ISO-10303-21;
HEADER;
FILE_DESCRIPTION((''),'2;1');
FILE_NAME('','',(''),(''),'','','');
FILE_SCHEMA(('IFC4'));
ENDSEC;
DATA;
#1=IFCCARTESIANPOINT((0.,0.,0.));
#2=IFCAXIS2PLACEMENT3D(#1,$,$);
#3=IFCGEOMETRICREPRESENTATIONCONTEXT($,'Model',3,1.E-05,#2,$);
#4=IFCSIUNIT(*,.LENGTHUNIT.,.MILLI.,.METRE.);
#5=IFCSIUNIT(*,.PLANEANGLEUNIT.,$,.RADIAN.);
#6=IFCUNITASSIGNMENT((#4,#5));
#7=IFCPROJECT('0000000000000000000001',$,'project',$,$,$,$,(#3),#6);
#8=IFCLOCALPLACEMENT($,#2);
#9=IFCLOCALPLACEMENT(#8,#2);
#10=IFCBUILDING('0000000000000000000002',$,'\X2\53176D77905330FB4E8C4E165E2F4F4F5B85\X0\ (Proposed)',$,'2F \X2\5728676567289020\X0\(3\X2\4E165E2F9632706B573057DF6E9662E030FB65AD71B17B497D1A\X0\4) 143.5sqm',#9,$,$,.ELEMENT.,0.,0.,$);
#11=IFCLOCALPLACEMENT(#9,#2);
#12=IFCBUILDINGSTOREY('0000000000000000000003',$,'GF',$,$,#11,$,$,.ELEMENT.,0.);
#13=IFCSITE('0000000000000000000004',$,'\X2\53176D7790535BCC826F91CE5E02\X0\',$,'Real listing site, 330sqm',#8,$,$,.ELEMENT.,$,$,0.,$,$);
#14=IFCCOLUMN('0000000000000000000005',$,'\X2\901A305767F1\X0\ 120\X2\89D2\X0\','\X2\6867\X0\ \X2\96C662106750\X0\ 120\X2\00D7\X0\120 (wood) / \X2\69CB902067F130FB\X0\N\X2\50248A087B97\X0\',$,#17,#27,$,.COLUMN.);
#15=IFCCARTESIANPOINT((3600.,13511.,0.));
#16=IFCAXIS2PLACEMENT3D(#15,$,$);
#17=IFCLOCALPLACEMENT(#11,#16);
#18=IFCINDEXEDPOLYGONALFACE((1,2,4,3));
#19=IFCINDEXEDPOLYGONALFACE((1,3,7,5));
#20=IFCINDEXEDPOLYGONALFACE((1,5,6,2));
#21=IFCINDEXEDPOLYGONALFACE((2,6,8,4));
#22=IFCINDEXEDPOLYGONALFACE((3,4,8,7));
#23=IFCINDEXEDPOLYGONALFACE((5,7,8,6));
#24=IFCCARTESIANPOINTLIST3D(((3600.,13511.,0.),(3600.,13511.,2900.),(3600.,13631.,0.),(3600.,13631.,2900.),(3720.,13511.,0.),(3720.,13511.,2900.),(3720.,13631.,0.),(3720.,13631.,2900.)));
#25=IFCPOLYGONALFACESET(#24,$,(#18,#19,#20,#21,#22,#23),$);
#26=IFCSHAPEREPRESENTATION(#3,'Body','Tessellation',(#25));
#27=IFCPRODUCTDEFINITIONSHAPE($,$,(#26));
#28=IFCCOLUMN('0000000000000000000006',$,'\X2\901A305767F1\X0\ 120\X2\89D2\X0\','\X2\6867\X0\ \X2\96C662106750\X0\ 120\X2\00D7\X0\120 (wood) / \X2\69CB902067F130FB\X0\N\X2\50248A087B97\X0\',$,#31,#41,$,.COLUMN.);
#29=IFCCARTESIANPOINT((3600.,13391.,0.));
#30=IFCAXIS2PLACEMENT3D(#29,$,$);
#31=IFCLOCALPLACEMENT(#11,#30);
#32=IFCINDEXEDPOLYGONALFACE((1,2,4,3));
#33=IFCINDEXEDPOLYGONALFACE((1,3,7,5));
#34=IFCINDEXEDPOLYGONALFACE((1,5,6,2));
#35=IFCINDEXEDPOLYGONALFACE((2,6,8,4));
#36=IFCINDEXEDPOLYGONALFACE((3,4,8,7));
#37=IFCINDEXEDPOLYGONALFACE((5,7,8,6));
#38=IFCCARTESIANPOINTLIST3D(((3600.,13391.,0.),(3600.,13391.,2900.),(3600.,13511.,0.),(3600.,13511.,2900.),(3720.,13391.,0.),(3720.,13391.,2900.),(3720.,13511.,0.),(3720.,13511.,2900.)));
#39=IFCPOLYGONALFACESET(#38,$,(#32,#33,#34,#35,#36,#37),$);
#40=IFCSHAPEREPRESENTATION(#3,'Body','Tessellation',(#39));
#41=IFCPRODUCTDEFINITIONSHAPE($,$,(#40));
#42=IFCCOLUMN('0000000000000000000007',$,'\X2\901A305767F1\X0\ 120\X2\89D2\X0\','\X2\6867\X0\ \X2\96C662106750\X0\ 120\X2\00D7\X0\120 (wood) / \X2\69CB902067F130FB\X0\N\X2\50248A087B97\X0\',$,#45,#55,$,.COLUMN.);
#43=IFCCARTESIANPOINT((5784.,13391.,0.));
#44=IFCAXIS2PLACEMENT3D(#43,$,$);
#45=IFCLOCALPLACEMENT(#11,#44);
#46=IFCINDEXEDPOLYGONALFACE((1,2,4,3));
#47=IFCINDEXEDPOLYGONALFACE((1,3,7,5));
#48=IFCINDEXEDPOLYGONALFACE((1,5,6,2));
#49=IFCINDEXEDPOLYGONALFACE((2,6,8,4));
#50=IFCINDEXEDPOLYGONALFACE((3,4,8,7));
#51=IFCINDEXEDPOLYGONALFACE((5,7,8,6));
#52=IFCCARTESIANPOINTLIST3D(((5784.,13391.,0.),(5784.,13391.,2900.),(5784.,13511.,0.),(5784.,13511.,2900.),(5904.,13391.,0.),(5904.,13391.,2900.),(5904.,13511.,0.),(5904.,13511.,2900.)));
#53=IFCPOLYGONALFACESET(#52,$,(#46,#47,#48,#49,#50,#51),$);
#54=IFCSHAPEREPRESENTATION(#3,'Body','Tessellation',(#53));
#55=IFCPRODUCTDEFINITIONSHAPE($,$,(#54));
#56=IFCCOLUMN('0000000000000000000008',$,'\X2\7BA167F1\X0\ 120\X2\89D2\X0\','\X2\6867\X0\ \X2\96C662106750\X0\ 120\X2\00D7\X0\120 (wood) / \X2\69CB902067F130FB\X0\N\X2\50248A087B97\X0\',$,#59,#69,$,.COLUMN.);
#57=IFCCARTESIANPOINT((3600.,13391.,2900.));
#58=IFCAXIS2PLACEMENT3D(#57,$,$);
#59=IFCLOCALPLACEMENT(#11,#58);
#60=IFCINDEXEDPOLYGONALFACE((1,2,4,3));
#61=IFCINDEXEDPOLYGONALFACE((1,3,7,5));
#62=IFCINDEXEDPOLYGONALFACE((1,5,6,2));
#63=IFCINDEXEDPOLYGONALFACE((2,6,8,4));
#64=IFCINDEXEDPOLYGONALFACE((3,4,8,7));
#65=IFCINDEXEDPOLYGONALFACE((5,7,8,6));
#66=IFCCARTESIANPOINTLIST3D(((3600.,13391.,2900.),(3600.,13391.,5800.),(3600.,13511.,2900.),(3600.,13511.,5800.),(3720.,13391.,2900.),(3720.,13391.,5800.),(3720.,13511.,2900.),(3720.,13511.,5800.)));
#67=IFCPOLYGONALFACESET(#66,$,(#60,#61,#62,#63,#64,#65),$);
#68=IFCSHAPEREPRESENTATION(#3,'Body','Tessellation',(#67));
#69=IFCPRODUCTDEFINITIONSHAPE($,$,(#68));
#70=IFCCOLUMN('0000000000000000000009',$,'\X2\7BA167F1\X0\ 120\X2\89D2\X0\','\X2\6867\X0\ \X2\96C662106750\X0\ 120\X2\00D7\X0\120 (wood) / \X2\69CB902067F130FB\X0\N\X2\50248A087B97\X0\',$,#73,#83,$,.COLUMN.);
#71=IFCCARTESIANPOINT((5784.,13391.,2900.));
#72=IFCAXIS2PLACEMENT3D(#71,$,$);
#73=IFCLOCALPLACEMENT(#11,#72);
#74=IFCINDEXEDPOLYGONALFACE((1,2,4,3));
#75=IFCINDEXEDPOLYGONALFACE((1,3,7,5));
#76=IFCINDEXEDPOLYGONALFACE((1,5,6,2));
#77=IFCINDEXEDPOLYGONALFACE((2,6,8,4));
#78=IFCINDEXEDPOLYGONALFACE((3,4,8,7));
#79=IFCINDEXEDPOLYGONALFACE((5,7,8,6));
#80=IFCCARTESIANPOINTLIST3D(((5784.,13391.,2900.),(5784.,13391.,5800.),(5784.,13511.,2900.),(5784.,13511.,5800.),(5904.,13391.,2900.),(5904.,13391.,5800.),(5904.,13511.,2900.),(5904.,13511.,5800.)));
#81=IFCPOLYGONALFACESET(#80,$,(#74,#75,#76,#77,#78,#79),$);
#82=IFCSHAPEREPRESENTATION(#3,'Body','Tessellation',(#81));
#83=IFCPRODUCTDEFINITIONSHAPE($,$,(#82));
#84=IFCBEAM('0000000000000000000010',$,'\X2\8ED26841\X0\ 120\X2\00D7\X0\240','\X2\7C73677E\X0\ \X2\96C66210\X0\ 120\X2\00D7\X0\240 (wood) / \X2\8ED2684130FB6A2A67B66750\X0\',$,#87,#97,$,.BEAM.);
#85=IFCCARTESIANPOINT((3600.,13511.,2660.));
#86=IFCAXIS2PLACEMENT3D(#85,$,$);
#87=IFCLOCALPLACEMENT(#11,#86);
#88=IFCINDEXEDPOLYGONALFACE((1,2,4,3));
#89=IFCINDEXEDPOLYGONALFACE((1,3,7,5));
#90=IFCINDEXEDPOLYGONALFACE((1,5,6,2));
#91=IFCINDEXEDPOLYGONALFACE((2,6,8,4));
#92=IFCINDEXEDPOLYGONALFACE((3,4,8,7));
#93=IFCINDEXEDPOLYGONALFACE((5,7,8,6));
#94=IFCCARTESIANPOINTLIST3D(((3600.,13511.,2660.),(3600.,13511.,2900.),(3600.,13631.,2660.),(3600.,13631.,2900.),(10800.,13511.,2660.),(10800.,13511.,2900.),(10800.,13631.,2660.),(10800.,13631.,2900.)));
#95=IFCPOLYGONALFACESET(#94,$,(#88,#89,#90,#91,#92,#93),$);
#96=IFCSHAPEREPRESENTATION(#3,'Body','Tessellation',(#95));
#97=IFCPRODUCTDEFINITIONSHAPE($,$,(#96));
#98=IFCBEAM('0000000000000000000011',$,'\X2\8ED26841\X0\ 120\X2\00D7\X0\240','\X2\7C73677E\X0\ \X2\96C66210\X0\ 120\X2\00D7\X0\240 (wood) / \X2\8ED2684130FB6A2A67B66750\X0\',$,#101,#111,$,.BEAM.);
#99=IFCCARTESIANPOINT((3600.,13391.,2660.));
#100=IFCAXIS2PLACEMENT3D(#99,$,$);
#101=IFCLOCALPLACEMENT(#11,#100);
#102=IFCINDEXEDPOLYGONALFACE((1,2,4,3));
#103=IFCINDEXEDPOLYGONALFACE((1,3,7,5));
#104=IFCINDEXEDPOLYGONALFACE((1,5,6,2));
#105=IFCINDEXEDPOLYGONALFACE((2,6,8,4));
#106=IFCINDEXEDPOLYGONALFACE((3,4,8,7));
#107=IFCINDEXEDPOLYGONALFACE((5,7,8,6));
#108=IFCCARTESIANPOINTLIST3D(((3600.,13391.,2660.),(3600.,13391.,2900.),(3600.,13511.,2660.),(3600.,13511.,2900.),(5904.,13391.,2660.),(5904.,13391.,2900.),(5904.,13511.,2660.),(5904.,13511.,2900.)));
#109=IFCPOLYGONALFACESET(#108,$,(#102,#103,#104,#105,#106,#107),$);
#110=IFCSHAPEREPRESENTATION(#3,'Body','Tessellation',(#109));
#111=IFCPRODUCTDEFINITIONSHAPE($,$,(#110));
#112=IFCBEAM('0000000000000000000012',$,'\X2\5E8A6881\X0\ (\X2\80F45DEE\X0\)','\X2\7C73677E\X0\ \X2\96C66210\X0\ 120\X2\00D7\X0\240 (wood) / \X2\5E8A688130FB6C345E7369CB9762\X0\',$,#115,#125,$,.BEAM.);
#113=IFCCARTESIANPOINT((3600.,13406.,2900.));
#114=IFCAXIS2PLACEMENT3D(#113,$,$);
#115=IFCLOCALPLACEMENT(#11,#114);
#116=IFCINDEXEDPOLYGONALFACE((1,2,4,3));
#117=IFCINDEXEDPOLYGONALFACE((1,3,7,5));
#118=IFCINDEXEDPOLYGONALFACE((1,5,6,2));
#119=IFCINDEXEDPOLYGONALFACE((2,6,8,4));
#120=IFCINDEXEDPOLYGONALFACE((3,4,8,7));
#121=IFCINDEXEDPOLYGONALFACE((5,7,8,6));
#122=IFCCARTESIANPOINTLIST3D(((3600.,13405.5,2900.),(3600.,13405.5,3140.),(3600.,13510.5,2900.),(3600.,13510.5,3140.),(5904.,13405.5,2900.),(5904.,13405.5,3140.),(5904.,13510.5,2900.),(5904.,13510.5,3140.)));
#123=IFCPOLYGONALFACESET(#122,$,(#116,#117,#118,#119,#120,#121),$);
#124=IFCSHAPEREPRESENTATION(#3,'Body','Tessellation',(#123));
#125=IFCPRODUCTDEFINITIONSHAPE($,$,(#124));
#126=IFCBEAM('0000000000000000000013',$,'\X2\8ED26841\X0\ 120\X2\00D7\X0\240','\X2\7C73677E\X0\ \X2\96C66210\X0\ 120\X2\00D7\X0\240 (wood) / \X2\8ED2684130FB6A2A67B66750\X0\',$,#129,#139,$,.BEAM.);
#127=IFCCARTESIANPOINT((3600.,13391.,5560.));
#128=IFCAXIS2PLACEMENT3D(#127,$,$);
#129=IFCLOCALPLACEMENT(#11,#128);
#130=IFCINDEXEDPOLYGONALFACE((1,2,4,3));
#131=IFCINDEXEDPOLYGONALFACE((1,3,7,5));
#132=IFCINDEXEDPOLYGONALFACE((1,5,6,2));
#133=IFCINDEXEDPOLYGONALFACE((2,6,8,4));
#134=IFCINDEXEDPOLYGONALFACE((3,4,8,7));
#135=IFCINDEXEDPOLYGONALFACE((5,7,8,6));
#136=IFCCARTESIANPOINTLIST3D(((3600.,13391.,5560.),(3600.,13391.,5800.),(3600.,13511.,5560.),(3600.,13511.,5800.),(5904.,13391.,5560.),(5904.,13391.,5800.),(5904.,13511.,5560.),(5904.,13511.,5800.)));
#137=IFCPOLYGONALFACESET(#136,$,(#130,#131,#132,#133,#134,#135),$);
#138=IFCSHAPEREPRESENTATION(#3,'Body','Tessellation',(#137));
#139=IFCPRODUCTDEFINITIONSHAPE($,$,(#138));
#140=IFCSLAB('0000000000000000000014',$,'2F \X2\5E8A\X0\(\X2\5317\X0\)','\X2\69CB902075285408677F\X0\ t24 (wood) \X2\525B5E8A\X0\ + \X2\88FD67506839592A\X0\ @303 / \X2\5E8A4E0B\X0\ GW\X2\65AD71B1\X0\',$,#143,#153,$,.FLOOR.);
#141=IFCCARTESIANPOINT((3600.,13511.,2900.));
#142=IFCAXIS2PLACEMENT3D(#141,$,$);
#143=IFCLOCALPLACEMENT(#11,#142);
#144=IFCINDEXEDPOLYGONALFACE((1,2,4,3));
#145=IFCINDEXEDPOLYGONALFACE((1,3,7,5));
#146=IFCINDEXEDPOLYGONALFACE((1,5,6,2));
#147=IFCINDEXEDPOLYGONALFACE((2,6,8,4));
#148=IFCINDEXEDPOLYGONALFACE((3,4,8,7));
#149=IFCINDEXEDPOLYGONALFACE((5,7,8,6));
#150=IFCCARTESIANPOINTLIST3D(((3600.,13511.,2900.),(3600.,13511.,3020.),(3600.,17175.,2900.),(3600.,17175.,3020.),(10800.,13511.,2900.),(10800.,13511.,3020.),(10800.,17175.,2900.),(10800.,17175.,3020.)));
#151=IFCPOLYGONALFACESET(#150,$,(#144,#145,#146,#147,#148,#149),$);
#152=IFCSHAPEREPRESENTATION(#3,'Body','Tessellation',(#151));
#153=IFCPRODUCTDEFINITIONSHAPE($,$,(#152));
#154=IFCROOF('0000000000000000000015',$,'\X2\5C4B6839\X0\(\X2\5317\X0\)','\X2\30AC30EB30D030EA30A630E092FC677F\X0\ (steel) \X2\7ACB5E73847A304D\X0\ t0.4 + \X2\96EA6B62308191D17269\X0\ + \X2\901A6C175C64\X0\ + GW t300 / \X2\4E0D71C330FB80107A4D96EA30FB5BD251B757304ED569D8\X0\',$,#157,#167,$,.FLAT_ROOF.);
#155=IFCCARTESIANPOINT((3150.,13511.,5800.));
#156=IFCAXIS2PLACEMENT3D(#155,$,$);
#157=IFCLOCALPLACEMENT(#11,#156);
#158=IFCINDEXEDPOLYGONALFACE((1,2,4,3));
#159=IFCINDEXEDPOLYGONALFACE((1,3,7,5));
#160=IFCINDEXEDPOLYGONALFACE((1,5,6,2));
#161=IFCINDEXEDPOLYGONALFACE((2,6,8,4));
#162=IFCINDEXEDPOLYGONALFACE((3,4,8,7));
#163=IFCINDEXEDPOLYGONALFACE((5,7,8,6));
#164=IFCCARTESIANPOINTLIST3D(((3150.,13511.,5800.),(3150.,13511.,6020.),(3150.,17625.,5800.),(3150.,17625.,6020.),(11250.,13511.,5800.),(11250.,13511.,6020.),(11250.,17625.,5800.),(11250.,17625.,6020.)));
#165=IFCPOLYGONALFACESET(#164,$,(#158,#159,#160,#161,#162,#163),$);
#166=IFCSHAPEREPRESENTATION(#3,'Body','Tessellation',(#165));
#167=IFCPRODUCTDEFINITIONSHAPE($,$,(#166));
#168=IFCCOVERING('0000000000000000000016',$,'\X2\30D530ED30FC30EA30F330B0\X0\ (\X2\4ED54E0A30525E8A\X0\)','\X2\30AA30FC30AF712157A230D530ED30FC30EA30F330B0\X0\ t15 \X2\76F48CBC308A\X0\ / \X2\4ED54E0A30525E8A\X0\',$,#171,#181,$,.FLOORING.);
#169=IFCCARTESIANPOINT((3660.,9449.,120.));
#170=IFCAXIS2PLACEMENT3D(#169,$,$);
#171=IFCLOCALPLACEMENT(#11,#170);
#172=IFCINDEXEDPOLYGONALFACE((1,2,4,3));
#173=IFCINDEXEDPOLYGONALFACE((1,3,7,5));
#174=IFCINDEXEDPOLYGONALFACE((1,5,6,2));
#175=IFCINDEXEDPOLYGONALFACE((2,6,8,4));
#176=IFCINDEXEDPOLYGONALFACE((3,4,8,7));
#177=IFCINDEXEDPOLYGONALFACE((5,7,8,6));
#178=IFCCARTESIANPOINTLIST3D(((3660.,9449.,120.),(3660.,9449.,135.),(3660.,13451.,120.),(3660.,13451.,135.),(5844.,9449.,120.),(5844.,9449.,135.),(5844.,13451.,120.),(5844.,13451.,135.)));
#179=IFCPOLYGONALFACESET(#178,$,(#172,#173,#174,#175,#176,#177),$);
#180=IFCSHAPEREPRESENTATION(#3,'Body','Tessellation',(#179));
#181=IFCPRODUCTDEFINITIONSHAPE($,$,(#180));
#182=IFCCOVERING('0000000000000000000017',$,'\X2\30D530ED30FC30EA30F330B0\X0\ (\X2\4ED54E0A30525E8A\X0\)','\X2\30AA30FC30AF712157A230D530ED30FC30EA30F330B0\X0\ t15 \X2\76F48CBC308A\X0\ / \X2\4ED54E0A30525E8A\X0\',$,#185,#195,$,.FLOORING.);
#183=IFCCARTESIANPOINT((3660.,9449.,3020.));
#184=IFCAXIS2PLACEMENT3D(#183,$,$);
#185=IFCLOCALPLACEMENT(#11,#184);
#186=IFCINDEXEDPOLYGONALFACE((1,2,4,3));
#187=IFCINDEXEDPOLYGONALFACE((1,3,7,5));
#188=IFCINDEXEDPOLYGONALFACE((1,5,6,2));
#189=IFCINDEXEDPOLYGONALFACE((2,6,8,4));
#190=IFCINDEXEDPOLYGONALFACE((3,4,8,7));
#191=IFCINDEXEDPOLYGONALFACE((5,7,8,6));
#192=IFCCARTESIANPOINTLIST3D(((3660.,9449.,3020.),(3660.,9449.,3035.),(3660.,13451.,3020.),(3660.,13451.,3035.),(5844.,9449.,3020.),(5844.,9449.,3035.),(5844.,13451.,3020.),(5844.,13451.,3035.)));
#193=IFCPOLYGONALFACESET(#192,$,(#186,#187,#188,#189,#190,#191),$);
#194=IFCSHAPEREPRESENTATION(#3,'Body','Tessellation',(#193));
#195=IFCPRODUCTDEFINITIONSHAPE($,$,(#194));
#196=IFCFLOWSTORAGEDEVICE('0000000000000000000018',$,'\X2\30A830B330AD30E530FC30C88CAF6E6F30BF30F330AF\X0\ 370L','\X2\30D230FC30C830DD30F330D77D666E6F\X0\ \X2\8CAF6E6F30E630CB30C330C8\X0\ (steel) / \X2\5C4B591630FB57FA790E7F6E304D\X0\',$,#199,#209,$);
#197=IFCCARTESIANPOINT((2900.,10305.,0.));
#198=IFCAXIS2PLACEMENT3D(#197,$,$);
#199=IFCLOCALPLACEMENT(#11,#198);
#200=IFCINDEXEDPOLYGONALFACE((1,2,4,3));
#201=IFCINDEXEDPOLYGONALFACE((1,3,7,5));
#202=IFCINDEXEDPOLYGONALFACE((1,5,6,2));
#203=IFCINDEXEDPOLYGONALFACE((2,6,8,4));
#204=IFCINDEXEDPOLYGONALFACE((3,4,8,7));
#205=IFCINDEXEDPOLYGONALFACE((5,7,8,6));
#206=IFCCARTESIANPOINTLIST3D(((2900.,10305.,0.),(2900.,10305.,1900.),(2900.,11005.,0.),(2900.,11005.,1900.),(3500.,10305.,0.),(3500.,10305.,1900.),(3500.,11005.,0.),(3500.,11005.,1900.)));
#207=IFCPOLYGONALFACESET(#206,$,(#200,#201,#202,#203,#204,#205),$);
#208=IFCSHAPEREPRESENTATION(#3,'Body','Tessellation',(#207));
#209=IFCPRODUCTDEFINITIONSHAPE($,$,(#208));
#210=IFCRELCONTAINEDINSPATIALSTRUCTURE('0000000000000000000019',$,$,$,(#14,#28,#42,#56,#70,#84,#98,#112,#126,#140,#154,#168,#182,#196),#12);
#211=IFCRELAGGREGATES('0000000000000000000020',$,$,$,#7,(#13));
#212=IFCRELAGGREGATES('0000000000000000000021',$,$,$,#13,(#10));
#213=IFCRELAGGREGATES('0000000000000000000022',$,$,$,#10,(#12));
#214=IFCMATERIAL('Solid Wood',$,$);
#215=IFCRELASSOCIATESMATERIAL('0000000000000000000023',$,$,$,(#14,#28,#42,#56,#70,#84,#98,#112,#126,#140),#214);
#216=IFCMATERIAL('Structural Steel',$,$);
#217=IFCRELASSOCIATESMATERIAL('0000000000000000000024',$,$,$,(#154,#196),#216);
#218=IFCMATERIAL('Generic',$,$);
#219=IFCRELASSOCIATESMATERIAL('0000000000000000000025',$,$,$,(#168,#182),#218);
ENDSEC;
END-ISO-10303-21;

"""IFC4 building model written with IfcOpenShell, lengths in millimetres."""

from ifc_helpers import new_model, si_unit, frame, frame_2d, origin, place, context, project, spatial, rectangle, extrude, material, element, save


model = new_model("IFC4")

# Units and contexts
model_context = context("Model", 3, precision=1e-05, world=origin())
ifc_project = project(units=[si_unit("LENGTHUNIT", "METRE", prefix="MILLI"), si_unit("PLANEANGLEUNIT", "RADIAN")], contexts=[model_context])

# Site, building, storey
site_placement = place(None, origin())
site = spatial("IfcSite", under=ifc_project, at=site_placement, Name="北海道富良野市", ObjectType="Real listing site, 330sqm", CompositionType="ELEMENT", RefElevation=0.0)
building_placement = place(site_placement, origin())
building = spatial("IfcBuilding", under=site, at=building_placement, Name="北海道・二世帯住宅 (Proposed)", ObjectType="2F 在来木造(3世帯防火地域準拠・断熱等級4) 143.5sqm", CompositionType="ELEMENT", ElevationOfRefHeight=0.0, ElevationOfTerrain=0.0)
storey_placement = place(building_placement, origin())
storey = spatial("IfcBuildingStorey", under=building, at=storey_placement, Name="GF", CompositionType="ELEMENT", Elevation=0.0)

# Columns
ifc_material_1 = material(Name="Solid Wood")
column_1_placement = place(storey_placement, frame((3600.0, 13511.0, 0.0)))
element("IfcColumn", 1, at=column_1_placement, inside=storey, material=ifc_material_1, Name="通し柱 120角", Description="桧 集成材 120×120 (wood) / 構造柱・N値計算", PredefinedType="COLUMN", context=model_context, shape_type="SweptSolid", body=[
    extrude(rectangle(XDim=120.0, YDim=120.0, at=frame_2d((60.0, 60.0))), frame((3600.0, 13511.0, 0.0)), (0.0, 0.0, 1.0), 2900.0),
])
column_2_placement = place(storey_placement, frame((3600.0, 13391.0, 0.0)))
element("IfcColumn", 2, at=column_2_placement, inside=storey, material=ifc_material_1, Name="通し柱 120角", Description="桧 集成材 120×120 (wood) / 構造柱・N値計算", PredefinedType="COLUMN", context=model_context, shape_type="SweptSolid", body=[
    extrude(rectangle(XDim=120.0, YDim=120.0, at=frame_2d((60.0, 60.0))), frame((3600.0, 13391.0, 0.0)), (0.0, 0.0, 1.0), 2900.0),
])
column_3_placement = place(storey_placement, frame((5784.0, 13391.0, 0.0)))
element("IfcColumn", 3, at=column_3_placement, inside=storey, material=ifc_material_1, Name="通し柱 120角", Description="桧 集成材 120×120 (wood) / 構造柱・N値計算", PredefinedType="COLUMN", context=model_context, shape_type="SweptSolid", body=[
    extrude(rectangle(XDim=120.0, YDim=120.0, at=frame_2d((60.0, 60.0))), frame((5784.0, 13391.0, 0.0)), (0.0, 0.0, 1.0), 2900.0),
])
column_4_placement = place(storey_placement, frame((3600.0, 13391.0, 2900.0)))
element("IfcColumn", 4, at=column_4_placement, inside=storey, material=ifc_material_1, Name="管柱 120角", Description="桧 集成材 120×120 (wood) / 構造柱・N値計算", PredefinedType="COLUMN", context=model_context, shape_type="SweptSolid", body=[
    extrude(rectangle(XDim=120.0, YDim=120.0, at=frame_2d((60.0, 60.0))), frame((3600.0, 13391.0, 2900.0)), (0.0, 0.0, 1.0), 2900.0),
])
column_5_placement = place(storey_placement, frame((5784.0, 13391.0, 2900.0)))
element("IfcColumn", 5, at=column_5_placement, inside=storey, material=ifc_material_1, Name="管柱 120角", Description="桧 集成材 120×120 (wood) / 構造柱・N値計算", PredefinedType="COLUMN", context=model_context, shape_type="SweptSolid", body=[
    extrude(rectangle(XDim=120.0, YDim=120.0, at=frame_2d((60.0, 60.0))), frame((5784.0, 13391.0, 2900.0)), (0.0, 0.0, 1.0), 2900.0),
])

# Beams
beam_1_placement = place(storey_placement, frame((3600.0, 13511.0, 2660.0)))
element("IfcBeam", 6, at=beam_1_placement, inside=storey, material=ifc_material_1, Name="軒桁 120×240", Description="米松 集成 120×240 (wood) / 軒桁・横架材", PredefinedType="BEAM", context=model_context, shape_type="SweptSolid", body=[
    extrude(rectangle(XDim=7200.0, YDim=120.0, at=frame_2d((3600.0, 60.0))), frame((3600.0, 13511.0, 2660.0)), (0.0, 0.0, 1.0), 240.0),
])
beam_2_placement = place(storey_placement, frame((3600.0, 13391.0, 2660.0)))
element("IfcBeam", 7, at=beam_2_placement, inside=storey, material=ifc_material_1, Name="軒桁 120×240", Description="米松 集成 120×240 (wood) / 軒桁・横架材", PredefinedType="BEAM", context=model_context, shape_type="SweptSolid", body=[
    extrude(rectangle(XDim=2304.0, YDim=120.0, at=frame_2d((1152.0, 60.0))), frame((3600.0, 13391.0, 2660.0)), (0.0, 0.0, 1.0), 240.0),
])
beam_3_placement = place(storey_placement, frame((3600.0, 13406.0, 2900.0)))
element("IfcBeam", 8, at=beam_3_placement, inside=storey, material=ifc_material_1, Name="床梁 (胴差)", Description="米松 集成 120×240 (wood) / 床梁・水平構面", PredefinedType="BEAM", context=model_context, shape_type="SweptSolid", body=[
    extrude(rectangle(XDim=2304.0, YDim=105.0, at=frame_2d((1152.0, 52.0))), frame((3600.0, 13406.0, 2900.0)), (0.0, 0.0, 1.0), 240.0),
])
beam_4_placement = place(storey_placement, frame((3600.0, 13391.0, 5560.0)))
element("IfcBeam", 9, at=beam_4_placement, inside=storey, material=ifc_material_1, Name="軒桁 120×240", Description="米松 集成 120×240 (wood) / 軒桁・横架材", PredefinedType="BEAM", context=model_context, shape_type="SweptSolid", body=[
    extrude(rectangle(XDim=2304.0, YDim=120.0, at=frame_2d((1152.0, 60.0))), frame((3600.0, 13391.0, 5560.0)), (0.0, 0.0, 1.0), 240.0),
])

# Slab
slab_1_placement = place(storey_placement, frame((3600.0, 13511.0, 2900.0)))
element("IfcSlab", 10, at=slab_1_placement, inside=storey, material=ifc_material_1, Name="2F 床(北)", Description="構造用合板 t24 (wood) 剛床 + 製材根太 @303 / 床下 GW断熱", PredefinedType="FLOOR", context=model_context, shape_type="SweptSolid", body=[
    extrude(rectangle(XDim=7200.0, YDim=3664.0, at=frame_2d((3600.0, 1832.0))), frame((3600.0, 13511.0, 2900.0)), (0.0, 0.0, 1.0), 120.0),
])

# Roof
ifc_material_2 = material(Name="Structural Steel")
for number, where, name in (
    (11, (3150.0, 13511.0, 5800.0), "屋根(北)"),
):
    element("IfcRoof", number, at=place(storey_placement, frame(where)), inside=storey, material=ifc_material_2, Name=name, Description="ガルバリウム鋼板 (steel) 立平葺き t0.4 + 雪止め金物 + 通気層 + GW t300 / 不燃・耐積雪・寒冷地仕様", PredefinedType="FLAT_ROOF", context=model_context, shape_type="SweptSolid", body=[
        extrude(rectangle(XDim=8100.0, YDim=4114.0, at=frame_2d((4050.0, 2057.0))), frame((3150.0, 13511.0, 5800.0)), (0.0, 0.0, 1.0), 220.0),
    ])

# Coverings
ifc_material_3 = material(Name="Generic")
covering_1_placement = place(storey_placement, frame((3660.0, 9449.0, 120.0)))
element("IfcCovering", 12, at=covering_1_placement, inside=storey, material=ifc_material_3, Name="フローリング (仕上げ床)", Description="オーク無垢フローリング t15 直貼り / 仕上げ床", PredefinedType="FLOORING", context=model_context, shape_type="SweptSolid", body=[
    extrude(rectangle(XDim=2184.0, YDim=4002.0, at=frame_2d((1092.0, 2001.0))), frame((3660.0, 9449.0, 120.0)), (0.0, 0.0, 1.0), 15.0),
])
covering_2_placement = place(storey_placement, frame((3660.0, 9449.0, 3020.0)))
element("IfcCovering", 13, at=covering_2_placement, inside=storey, material=ifc_material_3, Name="フローリング (仕上げ床)", Description="オーク無垢フローリング t15 直貼り / 仕上げ床", PredefinedType="FLOORING", context=model_context, shape_type="SweptSolid", body=[
    extrude(rectangle(XDim=2184.0, YDim=4002.0, at=frame_2d((1092.0, 2001.0))), frame((3660.0, 9449.0, 3020.0)), (0.0, 0.0, 1.0), 15.0),
])

# Flow storage device
flow_storage_device_placement = place(storey_placement, frame((2900.0, 10305.0, 0.0)))
element("IfcFlowStorageDevice", 14, at=flow_storage_device_placement, inside=storey, material=ifc_material_2, Name="エコキュート貯湯タンク 370L", Description="ヒートポンプ給湯 貯湯ユニット (steel) / 屋外・基礎置き", context=model_context, shape_type="SweptSolid", body=[
    extrude(rectangle(XDim=600.0, YDim=700.0, at=frame_2d((300.0, 350.0))), frame((2900.0, 10305.0, 0.0)), (0.0, 0.0, 1.0), 1900.0),
])

save(model, "model.ifc")
